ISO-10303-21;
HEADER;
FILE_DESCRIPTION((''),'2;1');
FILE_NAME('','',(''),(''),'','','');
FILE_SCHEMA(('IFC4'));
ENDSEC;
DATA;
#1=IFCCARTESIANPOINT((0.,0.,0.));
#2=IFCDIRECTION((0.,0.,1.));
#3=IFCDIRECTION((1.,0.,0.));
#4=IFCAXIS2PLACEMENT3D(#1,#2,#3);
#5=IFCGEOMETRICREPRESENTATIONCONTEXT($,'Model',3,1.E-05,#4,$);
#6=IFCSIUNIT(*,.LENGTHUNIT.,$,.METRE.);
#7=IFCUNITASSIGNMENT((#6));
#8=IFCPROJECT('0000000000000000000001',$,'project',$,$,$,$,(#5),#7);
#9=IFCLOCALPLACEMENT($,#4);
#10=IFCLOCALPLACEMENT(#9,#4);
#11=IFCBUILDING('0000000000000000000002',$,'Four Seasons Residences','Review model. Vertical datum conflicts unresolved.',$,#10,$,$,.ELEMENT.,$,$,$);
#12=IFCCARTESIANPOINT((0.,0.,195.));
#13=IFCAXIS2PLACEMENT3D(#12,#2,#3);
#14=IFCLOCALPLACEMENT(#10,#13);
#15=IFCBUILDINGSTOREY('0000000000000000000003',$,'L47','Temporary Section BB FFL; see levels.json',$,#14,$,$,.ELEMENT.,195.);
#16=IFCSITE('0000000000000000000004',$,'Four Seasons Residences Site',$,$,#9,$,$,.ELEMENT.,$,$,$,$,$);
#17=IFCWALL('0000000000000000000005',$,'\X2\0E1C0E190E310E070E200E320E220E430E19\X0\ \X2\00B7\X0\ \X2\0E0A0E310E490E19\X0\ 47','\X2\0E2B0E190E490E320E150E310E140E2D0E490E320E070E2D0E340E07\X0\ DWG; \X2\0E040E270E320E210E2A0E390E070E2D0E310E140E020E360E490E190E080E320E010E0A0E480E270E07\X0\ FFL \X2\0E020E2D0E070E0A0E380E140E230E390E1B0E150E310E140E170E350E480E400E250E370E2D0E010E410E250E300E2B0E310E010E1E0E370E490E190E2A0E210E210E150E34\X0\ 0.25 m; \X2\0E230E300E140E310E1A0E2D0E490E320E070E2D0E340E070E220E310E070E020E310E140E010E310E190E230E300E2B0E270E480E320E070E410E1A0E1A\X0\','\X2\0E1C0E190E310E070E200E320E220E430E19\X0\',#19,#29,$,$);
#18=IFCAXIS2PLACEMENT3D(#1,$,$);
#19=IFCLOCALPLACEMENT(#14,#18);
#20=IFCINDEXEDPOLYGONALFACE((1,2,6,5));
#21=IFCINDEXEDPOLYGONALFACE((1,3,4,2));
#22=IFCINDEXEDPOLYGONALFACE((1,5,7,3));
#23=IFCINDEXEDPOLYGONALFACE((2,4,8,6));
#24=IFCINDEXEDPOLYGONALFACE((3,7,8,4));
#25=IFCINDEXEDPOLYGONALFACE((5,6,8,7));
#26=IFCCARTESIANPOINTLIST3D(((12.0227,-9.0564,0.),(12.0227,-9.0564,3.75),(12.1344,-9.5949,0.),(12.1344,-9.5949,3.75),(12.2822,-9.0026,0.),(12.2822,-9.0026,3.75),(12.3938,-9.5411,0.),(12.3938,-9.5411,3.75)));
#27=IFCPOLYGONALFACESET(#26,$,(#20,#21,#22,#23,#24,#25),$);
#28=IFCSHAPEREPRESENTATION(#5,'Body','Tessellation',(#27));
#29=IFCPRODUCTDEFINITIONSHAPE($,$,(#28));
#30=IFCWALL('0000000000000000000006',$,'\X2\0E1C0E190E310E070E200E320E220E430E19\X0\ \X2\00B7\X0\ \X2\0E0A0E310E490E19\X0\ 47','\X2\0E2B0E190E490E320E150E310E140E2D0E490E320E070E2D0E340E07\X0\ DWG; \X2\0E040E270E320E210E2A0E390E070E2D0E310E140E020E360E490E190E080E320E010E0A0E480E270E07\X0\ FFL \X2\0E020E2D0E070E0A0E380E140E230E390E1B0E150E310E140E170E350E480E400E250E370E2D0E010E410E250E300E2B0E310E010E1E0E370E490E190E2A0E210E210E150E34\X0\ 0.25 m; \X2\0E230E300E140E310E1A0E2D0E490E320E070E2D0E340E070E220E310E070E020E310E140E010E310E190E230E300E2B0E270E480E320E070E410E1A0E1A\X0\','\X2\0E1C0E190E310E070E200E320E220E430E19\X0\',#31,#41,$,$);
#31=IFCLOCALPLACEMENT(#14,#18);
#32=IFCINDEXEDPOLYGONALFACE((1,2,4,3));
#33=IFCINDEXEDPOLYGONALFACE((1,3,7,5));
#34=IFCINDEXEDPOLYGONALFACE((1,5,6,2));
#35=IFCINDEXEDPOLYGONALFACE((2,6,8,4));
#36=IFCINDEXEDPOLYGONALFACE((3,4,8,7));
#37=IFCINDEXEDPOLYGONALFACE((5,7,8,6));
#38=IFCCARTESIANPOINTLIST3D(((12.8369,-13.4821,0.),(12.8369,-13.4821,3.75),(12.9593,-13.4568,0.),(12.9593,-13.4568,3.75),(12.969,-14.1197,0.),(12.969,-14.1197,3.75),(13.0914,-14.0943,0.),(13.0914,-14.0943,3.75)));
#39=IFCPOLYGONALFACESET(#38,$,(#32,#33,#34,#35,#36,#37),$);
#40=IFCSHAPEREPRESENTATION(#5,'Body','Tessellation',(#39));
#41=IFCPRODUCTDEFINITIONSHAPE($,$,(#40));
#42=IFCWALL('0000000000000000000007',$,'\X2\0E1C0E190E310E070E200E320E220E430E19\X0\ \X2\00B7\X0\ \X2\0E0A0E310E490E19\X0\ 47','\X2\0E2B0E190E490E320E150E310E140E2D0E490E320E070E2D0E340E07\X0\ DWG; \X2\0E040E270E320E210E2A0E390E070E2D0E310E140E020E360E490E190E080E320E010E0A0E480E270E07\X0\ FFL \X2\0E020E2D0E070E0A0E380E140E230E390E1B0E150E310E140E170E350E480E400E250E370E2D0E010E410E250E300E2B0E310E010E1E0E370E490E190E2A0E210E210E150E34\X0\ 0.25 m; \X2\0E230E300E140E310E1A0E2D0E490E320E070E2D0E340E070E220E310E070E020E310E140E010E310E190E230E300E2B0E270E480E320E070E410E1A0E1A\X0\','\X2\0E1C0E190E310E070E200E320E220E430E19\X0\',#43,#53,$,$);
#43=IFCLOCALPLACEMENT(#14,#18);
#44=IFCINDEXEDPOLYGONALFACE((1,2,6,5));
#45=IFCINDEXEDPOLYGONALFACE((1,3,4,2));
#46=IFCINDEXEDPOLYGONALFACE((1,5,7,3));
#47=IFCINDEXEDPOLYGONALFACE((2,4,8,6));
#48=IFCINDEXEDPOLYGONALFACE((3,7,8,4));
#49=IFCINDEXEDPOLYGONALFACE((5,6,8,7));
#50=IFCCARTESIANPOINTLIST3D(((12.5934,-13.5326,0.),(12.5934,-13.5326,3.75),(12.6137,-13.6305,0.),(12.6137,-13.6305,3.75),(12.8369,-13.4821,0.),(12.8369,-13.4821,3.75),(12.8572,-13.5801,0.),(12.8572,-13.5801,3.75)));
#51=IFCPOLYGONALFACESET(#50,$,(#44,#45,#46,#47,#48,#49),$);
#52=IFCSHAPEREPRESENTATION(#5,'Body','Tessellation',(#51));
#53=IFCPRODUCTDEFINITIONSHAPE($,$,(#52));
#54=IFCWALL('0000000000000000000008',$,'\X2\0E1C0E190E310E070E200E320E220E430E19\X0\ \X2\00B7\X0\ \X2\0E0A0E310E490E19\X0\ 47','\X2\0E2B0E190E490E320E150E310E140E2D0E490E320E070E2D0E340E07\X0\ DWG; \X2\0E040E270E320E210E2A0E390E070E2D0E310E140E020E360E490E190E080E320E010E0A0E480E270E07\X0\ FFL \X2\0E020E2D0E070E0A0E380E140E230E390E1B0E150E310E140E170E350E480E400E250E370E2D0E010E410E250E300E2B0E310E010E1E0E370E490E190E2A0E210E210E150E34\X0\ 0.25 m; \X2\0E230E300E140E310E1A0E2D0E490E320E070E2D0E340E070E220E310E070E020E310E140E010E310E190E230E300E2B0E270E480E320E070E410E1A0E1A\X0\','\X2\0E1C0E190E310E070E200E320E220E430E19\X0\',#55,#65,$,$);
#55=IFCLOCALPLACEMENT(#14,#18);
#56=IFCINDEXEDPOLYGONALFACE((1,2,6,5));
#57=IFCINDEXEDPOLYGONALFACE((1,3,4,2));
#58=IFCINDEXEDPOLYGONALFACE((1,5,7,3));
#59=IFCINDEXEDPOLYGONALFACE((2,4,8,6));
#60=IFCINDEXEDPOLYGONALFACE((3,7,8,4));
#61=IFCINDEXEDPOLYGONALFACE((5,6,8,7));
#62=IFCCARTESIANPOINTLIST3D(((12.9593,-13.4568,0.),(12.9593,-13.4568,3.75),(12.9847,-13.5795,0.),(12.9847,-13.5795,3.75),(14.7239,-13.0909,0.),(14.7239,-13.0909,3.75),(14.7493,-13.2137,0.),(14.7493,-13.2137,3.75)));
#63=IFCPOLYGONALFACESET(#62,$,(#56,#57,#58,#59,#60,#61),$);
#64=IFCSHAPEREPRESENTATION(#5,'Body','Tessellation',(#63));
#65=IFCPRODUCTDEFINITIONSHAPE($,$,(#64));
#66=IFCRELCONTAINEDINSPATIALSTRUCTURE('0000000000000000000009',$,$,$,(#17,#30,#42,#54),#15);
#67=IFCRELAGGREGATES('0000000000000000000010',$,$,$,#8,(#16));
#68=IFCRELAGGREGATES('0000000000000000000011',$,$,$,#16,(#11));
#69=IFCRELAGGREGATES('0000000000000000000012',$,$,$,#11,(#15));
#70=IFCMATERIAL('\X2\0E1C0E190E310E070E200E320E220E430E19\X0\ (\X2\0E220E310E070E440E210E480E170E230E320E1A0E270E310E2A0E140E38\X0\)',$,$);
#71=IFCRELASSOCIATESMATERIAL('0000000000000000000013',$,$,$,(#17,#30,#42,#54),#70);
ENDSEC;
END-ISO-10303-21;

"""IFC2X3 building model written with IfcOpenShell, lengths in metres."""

from ifc_helpers import new_model, si_unit, frame, origin_with_axes, place, context, project, spatial, polyline, outline, extrude, material, element, save


model = new_model("IFC2X3")

# Units and contexts
model_context = context("Model", 3, precision=1e-05, world=origin_with_axes())
ifc_project = project(units=[si_unit("LENGTHUNIT", "METRE")], contexts=[model_context])

# Site, building, storey
site_placement = place(None, origin_with_axes())
site = spatial("IfcSite", under=ifc_project, at=site_placement, Name="Four Seasons Residences Site", CompositionType="ELEMENT")
building_placement = place(site_placement, origin_with_axes())
building = spatial("IfcBuilding", under=site, at=building_placement, Name="Four Seasons Residences", Description="Review model. Vertical datum conflicts unresolved.", CompositionType="ELEMENT")
storey_placement = place(building_placement, frame((0.0, 0.0, 195.0), z_axis=(0.0, 0.0, 1.0), x_axis=(1.0, 0.0, 0.0)))
storey = spatial("IfcBuildingStorey", under=building, at=storey_placement, Name="L47", Description="Temporary Section BB FFL; see levels.json", CompositionType="ELEMENT", Elevation=195.0)

# Walls
ifc_material = material(Name="ผนังภายใน (ยังไม่ทราบวัสดุ)")
wall_1_placement = place(storey_placement, origin_with_axes())
element("IfcWall", 1, at=wall_1_placement, inside=storey, material=ifc_material, Name="ผนังภายใน · ชั้น 47", Description="หน้าตัดอ้างอิง DWG; ความสูงอัดขึ้นจากช่วง FFL ของชุดรูปตัดที่เลือกและหักพื้นสมมติ 0.25 m; ระดับอ้างอิงยังขัดกันระหว่างแบบ", ObjectType="ผนังภายใน", context=model_context, shape_type="SweptSolid", body=[
    extrude(outline(polyline([(12.0227, -9.0564), (12.2822, -9.0026), (12.3938, -9.5411), (12.1344, -9.5949), (12.0227, -9.0564)])), origin_with_axes(), (0.0, 0.0, 1.0), 3.75),
])
wall_2_placement = place(storey_placement, origin_with_axes())
element("IfcWall", 2, at=wall_2_placement, inside=storey, material=ifc_material, Name="ผนังภายใน · ชั้น 47", Description="หน้าตัดอ้างอิง DWG; ความสูงอัดขึ้นจากช่วง FFL ของชุดรูปตัดที่เลือกและหักพื้นสมมติ 0.25 m; ระดับอ้างอิงยังขัดกันระหว่างแบบ", ObjectType="ผนังภายใน", context=model_context, shape_type="SweptSolid", body=[
    extrude(outline(polyline([(12.8369, -13.4821), (12.969, -14.1197), (13.0914, -14.0943), (12.9593, -13.4568), (12.8369, -13.4821)])), origin_with_axes(), (0.0, 0.0, 1.0), 3.75),
])
wall_3_placement = place(storey_placement, origin_with_axes())
element("IfcWall", 3, at=wall_3_placement, inside=storey, material=ifc_material, Name="ผนังภายใน · ชั้น 47", Description="หน้าตัดอ้างอิง DWG; ความสูงอัดขึ้นจากช่วง FFL ของชุดรูปตัดที่เลือกและหักพื้นสมมติ 0.25 m; ระดับอ้างอิงยังขัดกันระหว่างแบบ", ObjectType="ผนังภายใน", context=model_context, shape_type="SweptSolid", body=[
    extrude(outline(polyline([(12.8572, -13.5801), (12.8369, -13.4821), (12.5934, -13.5326), (12.6137, -13.6305), (12.8572, -13.5801)])), origin_with_axes(), (0.0, 0.0, 1.0), 3.75),
])
wall_4_placement = place(storey_placement, origin_with_axes())
element("IfcWall", 4, at=wall_4_placement, inside=storey, material=ifc_material, Name="ผนังภายใน · ชั้น 47", Description="หน้าตัดอ้างอิง DWG; ความสูงอัดขึ้นจากช่วง FFL ของชุดรูปตัดที่เลือกและหักพื้นสมมติ 0.25 m; ระดับอ้างอิงยังขัดกันระหว่างแบบ", ObjectType="ผนังภายใน", context=model_context, shape_type="SweptSolid", body=[
    extrude(outline(polyline([(14.7493, -13.2137), (14.7239, -13.0909), (12.9593, -13.4568), (12.9847, -13.5795), (14.7493, -13.2137)])), origin_with_axes(), (0.0, 0.0, 1.0), 3.75),
])

save(model, "model.ifc")
